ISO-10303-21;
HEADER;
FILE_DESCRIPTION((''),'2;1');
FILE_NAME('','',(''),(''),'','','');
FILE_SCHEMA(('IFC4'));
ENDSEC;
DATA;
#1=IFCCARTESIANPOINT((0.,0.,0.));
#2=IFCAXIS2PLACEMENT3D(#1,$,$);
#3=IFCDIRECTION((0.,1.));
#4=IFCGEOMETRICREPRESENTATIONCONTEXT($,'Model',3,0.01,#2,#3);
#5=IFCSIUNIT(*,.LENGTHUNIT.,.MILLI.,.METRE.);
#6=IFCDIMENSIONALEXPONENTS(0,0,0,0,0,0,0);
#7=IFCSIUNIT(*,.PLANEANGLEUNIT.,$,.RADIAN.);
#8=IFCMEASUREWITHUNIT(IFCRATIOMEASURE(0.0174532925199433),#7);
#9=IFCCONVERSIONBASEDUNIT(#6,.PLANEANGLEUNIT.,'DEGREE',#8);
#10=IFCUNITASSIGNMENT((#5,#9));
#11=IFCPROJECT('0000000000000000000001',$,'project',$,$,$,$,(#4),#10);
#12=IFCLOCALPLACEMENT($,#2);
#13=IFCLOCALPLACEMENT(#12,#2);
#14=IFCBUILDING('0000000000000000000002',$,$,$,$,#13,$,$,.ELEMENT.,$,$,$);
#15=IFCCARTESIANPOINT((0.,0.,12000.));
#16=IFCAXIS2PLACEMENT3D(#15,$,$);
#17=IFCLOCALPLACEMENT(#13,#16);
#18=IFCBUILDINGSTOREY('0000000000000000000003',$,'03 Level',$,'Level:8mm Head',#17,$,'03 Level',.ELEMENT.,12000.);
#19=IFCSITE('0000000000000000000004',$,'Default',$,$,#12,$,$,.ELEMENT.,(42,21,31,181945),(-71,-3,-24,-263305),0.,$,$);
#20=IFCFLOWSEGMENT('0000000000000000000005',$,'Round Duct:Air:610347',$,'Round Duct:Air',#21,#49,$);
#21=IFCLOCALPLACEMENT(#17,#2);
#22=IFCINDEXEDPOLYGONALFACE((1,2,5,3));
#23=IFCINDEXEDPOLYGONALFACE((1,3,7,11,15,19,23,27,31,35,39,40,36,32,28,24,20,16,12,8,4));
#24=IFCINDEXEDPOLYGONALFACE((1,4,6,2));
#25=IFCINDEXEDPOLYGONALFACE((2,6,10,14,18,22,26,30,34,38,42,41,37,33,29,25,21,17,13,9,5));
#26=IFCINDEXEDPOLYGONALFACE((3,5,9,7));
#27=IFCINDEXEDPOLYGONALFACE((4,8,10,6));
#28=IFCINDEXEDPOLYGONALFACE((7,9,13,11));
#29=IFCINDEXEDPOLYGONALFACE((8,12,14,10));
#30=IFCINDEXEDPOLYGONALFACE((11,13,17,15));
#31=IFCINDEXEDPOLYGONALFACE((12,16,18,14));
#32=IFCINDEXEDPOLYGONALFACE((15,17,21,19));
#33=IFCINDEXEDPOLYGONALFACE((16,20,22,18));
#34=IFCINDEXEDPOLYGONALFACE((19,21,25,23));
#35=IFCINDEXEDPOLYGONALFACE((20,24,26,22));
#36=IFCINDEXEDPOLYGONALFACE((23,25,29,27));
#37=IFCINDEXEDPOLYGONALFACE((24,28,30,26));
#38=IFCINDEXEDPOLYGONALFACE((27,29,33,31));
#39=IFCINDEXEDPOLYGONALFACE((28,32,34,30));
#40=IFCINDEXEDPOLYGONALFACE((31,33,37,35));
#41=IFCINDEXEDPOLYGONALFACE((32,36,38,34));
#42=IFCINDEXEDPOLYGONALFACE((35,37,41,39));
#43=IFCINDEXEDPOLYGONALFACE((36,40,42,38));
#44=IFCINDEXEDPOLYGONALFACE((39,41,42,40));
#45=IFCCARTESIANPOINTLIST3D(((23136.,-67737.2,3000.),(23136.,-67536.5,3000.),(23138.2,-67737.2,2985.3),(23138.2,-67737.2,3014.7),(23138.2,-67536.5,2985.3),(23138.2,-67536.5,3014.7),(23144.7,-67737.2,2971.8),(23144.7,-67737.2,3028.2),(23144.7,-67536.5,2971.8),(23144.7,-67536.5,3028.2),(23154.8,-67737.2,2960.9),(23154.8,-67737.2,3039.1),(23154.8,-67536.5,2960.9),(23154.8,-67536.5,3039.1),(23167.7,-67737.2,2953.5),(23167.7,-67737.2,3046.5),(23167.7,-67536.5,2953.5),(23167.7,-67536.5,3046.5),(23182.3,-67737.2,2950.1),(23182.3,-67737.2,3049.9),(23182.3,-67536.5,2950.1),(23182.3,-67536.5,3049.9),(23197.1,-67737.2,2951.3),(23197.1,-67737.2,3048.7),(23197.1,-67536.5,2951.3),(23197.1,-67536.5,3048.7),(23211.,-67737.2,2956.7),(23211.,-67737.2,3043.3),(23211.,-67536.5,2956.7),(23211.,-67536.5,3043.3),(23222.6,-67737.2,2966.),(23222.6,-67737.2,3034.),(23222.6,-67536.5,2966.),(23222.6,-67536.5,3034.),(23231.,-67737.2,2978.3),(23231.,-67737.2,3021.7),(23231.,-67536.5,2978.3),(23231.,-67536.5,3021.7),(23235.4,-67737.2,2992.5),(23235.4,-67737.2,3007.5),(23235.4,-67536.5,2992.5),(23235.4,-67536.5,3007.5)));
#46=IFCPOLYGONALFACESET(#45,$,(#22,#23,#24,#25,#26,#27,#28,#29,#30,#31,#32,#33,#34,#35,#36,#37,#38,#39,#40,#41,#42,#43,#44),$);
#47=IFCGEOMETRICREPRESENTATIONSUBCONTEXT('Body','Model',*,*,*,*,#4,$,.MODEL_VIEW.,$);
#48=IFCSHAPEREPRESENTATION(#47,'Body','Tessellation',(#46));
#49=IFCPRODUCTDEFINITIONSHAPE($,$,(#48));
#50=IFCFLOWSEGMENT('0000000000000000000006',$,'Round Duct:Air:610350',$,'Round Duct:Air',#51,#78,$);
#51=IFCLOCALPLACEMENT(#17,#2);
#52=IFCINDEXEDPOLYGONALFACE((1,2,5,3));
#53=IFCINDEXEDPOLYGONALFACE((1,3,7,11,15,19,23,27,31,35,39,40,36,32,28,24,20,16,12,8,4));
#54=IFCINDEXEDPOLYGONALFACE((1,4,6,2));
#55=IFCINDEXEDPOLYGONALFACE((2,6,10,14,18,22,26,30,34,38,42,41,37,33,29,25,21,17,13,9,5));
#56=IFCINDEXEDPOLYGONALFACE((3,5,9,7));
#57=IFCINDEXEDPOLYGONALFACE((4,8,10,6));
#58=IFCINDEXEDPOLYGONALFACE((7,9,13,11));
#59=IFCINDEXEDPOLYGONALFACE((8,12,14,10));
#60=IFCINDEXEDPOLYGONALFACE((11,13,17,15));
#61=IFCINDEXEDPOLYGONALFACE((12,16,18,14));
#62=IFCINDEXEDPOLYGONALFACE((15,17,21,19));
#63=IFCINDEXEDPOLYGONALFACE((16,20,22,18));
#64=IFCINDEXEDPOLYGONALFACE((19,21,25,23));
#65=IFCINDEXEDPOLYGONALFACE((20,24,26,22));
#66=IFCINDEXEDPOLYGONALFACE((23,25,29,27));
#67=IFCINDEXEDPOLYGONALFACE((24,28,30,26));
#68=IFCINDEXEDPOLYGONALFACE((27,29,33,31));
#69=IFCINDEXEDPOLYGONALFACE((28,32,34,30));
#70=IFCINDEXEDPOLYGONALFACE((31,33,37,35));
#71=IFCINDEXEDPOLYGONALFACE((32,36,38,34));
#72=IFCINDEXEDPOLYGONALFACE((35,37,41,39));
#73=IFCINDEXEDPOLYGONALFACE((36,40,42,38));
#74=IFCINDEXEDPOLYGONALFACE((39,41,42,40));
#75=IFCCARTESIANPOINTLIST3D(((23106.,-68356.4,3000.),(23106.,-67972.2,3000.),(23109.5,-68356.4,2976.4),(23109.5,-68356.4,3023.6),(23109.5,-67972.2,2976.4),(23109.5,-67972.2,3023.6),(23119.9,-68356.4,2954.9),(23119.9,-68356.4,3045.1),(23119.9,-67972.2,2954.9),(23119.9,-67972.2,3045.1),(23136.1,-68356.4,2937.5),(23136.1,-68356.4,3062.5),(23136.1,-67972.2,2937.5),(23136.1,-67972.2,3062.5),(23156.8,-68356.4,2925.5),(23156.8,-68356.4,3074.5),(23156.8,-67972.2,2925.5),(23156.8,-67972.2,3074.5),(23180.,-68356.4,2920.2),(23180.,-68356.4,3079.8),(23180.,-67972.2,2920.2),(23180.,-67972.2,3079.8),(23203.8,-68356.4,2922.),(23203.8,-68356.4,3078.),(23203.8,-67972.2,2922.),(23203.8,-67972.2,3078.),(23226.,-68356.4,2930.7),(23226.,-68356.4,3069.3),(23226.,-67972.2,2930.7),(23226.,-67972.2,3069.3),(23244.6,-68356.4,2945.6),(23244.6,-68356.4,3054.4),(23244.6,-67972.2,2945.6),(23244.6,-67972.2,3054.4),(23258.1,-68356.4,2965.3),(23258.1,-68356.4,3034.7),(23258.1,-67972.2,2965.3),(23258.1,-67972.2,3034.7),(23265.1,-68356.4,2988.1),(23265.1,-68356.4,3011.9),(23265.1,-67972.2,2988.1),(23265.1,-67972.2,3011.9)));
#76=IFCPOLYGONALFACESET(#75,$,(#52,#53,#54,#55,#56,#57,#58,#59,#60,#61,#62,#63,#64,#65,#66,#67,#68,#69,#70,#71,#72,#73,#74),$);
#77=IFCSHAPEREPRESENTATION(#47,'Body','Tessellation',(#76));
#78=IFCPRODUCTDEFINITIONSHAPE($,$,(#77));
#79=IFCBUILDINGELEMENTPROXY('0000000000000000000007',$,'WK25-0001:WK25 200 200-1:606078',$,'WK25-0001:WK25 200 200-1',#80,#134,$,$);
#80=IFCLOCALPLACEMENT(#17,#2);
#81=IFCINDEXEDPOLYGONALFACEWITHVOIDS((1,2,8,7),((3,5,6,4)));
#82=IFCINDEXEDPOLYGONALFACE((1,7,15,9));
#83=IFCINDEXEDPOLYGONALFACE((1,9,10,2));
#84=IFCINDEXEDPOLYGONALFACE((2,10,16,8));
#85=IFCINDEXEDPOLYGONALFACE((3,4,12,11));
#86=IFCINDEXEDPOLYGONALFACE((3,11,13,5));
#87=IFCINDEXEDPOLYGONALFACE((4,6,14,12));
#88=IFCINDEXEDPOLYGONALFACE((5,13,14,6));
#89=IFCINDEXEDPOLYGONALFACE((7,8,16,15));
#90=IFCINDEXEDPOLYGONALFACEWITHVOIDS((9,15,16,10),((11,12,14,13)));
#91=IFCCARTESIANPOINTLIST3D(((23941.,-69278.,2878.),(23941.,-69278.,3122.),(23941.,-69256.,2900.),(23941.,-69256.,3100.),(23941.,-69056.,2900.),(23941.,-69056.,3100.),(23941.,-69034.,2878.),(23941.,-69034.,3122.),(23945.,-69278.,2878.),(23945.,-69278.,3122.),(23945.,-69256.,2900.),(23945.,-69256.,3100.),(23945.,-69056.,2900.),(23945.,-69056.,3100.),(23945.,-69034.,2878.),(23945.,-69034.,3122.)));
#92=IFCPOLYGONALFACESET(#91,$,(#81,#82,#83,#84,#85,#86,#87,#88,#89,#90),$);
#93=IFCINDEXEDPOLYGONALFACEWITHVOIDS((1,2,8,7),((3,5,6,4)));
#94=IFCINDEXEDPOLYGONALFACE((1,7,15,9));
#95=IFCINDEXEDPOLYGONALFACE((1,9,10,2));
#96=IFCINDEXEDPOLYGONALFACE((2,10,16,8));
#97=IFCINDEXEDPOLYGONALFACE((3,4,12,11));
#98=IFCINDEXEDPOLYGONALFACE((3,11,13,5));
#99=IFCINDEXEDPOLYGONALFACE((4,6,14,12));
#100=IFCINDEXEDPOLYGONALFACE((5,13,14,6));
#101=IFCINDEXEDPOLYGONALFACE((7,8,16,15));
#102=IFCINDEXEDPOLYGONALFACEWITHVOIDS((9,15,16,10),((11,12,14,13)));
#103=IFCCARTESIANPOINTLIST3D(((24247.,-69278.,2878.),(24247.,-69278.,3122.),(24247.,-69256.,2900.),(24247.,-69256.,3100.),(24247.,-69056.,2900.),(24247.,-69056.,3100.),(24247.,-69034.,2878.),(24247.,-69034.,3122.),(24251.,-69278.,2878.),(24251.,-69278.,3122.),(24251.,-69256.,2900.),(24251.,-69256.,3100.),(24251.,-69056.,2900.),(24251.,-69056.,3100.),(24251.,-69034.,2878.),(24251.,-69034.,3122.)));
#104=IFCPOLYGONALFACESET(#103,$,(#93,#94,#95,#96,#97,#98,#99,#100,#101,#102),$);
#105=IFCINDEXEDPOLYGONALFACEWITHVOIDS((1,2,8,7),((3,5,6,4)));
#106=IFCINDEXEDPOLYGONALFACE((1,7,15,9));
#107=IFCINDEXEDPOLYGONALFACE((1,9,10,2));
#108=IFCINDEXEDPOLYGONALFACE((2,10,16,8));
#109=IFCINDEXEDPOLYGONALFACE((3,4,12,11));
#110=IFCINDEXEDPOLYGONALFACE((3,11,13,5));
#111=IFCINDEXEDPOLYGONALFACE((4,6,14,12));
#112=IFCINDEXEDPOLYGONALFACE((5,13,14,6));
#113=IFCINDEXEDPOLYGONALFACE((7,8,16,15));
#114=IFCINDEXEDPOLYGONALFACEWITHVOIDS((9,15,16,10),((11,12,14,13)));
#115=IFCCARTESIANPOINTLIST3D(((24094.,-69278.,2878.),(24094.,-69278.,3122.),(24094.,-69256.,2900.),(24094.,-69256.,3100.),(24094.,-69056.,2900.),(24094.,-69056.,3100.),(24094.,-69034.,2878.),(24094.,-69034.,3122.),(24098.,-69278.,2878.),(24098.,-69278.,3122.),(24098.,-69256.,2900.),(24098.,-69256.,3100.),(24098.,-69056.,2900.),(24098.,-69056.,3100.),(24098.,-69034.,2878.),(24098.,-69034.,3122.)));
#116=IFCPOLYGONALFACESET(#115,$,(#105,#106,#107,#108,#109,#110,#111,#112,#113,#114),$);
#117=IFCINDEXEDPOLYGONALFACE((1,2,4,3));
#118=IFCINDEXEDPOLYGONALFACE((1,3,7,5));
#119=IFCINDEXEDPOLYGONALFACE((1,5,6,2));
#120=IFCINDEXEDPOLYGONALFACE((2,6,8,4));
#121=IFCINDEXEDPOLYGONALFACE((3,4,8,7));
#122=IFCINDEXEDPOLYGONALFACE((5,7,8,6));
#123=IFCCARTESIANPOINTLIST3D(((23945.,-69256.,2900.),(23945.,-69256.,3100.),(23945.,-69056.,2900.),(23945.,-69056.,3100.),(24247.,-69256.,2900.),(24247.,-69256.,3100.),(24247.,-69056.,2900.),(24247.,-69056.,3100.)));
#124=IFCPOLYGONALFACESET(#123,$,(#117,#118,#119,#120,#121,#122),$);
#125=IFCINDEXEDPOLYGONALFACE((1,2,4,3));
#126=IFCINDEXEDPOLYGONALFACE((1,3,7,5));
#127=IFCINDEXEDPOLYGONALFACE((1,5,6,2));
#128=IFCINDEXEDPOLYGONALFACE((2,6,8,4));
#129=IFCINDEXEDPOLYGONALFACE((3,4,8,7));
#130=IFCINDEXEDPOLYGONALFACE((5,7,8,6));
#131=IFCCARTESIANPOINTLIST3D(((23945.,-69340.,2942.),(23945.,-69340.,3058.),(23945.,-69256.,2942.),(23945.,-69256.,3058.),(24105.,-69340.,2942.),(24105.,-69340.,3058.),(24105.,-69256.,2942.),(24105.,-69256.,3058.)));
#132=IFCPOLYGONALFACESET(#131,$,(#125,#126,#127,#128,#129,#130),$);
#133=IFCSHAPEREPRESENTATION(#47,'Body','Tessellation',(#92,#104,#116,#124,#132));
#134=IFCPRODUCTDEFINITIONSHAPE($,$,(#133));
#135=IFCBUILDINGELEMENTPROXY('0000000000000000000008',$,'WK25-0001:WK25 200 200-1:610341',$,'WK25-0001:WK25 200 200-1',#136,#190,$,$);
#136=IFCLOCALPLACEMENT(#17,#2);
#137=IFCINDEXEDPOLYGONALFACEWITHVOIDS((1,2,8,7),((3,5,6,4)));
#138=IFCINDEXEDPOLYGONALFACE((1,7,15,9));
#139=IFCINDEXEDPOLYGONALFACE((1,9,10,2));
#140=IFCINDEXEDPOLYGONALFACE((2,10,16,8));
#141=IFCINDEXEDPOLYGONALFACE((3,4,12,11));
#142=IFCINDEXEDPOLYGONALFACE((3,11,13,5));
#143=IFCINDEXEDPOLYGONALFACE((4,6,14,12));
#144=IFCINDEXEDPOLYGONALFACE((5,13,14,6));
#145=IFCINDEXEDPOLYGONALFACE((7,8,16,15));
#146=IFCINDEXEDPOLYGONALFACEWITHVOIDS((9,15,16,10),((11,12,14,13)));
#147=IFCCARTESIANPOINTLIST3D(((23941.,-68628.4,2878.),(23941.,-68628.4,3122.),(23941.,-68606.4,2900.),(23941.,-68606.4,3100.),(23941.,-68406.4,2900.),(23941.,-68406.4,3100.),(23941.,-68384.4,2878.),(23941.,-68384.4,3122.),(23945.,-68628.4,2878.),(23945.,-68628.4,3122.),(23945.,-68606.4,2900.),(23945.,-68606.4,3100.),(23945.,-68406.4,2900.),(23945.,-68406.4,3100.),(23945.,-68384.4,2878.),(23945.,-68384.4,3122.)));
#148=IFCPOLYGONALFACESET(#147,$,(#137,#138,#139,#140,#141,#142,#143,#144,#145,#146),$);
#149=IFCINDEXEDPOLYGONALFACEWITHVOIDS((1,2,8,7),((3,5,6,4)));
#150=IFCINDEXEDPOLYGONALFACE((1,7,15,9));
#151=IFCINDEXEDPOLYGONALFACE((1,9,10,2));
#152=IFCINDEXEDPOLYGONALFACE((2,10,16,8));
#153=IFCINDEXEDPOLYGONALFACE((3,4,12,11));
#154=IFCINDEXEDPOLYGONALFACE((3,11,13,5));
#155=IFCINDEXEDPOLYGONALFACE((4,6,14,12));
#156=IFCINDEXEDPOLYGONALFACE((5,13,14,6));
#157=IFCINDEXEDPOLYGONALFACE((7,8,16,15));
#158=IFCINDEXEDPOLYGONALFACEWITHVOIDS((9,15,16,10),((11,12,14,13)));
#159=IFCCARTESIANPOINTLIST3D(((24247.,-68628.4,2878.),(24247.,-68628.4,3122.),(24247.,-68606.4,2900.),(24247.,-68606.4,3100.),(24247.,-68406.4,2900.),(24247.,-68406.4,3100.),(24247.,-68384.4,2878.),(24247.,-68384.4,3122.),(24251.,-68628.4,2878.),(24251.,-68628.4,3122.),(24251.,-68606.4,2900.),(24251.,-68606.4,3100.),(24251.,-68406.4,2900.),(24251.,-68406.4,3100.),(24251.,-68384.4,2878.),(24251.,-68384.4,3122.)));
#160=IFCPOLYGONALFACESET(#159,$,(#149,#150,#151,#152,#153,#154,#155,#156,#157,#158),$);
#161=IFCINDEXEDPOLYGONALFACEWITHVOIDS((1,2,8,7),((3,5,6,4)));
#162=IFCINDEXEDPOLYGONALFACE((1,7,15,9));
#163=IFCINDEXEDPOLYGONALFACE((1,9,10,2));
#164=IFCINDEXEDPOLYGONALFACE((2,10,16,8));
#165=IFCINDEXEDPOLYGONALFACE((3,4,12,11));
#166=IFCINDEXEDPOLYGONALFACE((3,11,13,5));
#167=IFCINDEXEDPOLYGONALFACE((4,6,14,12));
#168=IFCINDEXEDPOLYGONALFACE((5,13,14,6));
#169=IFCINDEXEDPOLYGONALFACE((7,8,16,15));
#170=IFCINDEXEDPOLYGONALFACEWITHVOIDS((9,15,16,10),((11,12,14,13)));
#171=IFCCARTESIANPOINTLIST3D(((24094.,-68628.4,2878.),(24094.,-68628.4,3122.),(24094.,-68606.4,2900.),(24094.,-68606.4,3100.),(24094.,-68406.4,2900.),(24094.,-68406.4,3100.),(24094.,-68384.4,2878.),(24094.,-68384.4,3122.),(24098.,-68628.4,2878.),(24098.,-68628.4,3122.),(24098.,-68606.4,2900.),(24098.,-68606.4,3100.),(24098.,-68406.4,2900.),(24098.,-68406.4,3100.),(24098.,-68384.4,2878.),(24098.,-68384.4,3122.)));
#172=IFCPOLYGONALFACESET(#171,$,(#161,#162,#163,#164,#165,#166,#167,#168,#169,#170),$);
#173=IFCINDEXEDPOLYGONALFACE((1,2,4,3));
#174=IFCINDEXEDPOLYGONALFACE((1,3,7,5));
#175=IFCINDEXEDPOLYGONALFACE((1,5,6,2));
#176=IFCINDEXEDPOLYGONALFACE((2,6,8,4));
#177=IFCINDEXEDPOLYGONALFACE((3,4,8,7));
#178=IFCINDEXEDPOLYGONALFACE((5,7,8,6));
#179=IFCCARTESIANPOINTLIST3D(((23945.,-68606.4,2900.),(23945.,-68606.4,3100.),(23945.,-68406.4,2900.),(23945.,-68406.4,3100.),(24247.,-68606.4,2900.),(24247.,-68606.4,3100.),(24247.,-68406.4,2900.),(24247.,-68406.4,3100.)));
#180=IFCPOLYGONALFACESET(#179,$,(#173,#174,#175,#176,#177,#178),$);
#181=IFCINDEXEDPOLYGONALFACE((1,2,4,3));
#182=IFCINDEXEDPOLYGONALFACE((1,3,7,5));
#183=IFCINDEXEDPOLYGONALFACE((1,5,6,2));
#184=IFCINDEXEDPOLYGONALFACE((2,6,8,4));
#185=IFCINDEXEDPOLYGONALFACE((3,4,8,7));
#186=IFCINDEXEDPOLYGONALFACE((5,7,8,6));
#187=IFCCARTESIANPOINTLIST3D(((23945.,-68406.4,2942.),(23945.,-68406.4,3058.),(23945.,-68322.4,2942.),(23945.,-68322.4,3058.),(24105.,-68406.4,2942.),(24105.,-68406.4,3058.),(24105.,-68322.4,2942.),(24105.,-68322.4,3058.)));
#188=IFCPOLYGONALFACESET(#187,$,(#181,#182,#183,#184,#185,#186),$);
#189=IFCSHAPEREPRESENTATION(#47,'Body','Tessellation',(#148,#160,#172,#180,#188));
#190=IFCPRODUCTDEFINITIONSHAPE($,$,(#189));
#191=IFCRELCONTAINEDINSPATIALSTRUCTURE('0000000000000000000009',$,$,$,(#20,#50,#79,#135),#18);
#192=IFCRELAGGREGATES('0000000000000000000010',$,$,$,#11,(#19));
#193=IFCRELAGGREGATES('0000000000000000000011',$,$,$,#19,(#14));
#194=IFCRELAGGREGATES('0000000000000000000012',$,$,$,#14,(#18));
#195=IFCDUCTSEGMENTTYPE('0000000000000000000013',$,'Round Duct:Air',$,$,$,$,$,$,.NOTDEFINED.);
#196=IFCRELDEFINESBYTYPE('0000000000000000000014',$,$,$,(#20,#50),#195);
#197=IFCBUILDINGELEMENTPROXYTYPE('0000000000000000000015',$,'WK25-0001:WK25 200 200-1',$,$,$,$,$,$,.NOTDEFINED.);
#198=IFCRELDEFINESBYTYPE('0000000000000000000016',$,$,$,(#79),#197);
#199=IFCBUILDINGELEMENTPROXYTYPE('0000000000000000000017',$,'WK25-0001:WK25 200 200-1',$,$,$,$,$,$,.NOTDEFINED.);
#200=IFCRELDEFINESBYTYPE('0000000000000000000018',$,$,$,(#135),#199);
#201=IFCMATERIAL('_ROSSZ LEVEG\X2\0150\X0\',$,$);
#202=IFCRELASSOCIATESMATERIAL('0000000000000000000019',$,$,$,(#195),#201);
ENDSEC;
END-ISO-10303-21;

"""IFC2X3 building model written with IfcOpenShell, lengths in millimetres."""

from ifc_helpers import new_model, entity, si_unit, converted_unit, direction, frame, frame_2d, origin, origin_2d_with_axis, place, context, subcontext, project, spatial, polyline, rectangle, circle, outline, extrude, source, transform, mapped, material, type_object, type_shapes, element, save


model = new_model("IFC2X3")

# Units and contexts
model_context = context("Model", 3, precision=0.01, world=origin(), true_north=direction((0.0, 1.0)))
body_context = subcontext(model_context, "Body", "Model", "MODEL_VIEW")
ifc_project = project(units=[si_unit("LENGTHUNIT", "METRE", prefix="MILLI"), converted_unit("PLANEANGLEUNIT", "DEGREE", entity("IfcRatioMeasure", 0.0174532925199433), si_unit("PLANEANGLEUNIT", "RADIAN"), dimensions=[0, 0, 0, 0, 0, 0, 0])], contexts=[model_context])

# Site, building, storey
site_placement = place(None, origin())
site = spatial("IfcSite", under=ifc_project, at=site_placement, Name="Default", CompositionType="ELEMENT", RefLatitude=(42, 21, 31, 181945), RefLongitude=(-71, -3, -24, -263305), RefElevation=0.0)
building_placement = place(site_placement, origin())
building = spatial("IfcBuilding", under=site, at=building_placement, CompositionType="ELEMENT")
storey_placement = place(building_placement, frame((0.0, 0.0, 12000.0)))
storey = spatial("IfcBuildingStorey", under=building, at=storey_placement, Name="03 Level", ObjectType="Level:8mm Head", LongName="03 Level", CompositionType="ELEMENT", Elevation=12000.0)

# Flow segments
ifc_material = material(Name="_ROSSZ LEVEGŐ")
duct_segment_type_1 = type_object("IfcDuctSegmentType", Name="Round Duct:Air", PredefinedType="NOTDEFINED", material=ifc_material)
flow_segment_1_placement = place(storey_placement, origin())
element("IfcFlowSegment", 1, at=flow_segment_1_placement, inside=storey, type_object=duct_segment_type_1, Name="Round Duct:Air:610347", ObjectType="Round Duct:Air", context=body_context, shape_type="SweptSolid", body=[
    extrude(circle(Radius=50.0, at=frame_2d((0.0, 0.0), x_axis=(1.0, 0.0))), frame((23186.0, -67737.2, 3000.0), z_axis=(0.0, 1.0, 0.0), x_axis=(-1.0, 0.0, 0.0)), (0.0, 0.0, 1.0), 200.7),
])
flow_segment_2_placement = place(storey_placement, origin())
element("IfcFlowSegment", 2, at=flow_segment_2_placement, inside=storey, type_object=duct_segment_type_1, Name="Round Duct:Air:610350", ObjectType="Round Duct:Air", context=body_context, shape_type="SweptSolid", body=[
    extrude(circle(Radius=80.0, at=frame_2d((0.0, 0.0), x_axis=(1.0, 0.0))), frame((23186.0, -68356.4, 3000.0), z_axis=(0.0, 1.0, 0.0), x_axis=(-1.0, 0.0, 0.0)), (0.0, 0.0, 1.0), 384.2),
])

# Building element proxies
building_element_proxy_type_1 = type_object("IfcBuildingElementProxyType", Name="WK25-0001:WK25 200 200-1", PredefinedType="NOTDEFINED")
shared_shape_1 = source(origin(), body_context, "Body", "SweptSolid", [
    extrude(outline(polyline([(-122.0, -122.0), (122.0, -122.0), (122.0, 122.0), (-122.0, 122.0), (-122.0, -122.0)]), holes=[polyline([(-100.0, -100.0), (-100.0, 100.0), (100.0, 100.0), (100.0, -100.0), (-100.0, -100.0)])]), frame((151.0, 0.0, 0.0), z_axis=(1.0, 0.0, 0.0), x_axis=(0.0, 0.0, -1.0)), (0.0, 0.0, 1.0), 4.0),
    extrude(outline(polyline([(-122.0, -122.0), (122.0, -122.0), (122.0, 122.0), (-122.0, 122.0), (-122.0, -122.0)]), holes=[polyline([(-100.0, -100.0), (-100.0, 100.0), (100.0, 100.0), (100.0, -100.0), (-100.0, -100.0)])]), frame((-155.0, 0.0, 0.0), z_axis=(1.0, 0.0, 0.0), x_axis=(0.0, -1.0, 0.0)), (0.0, 0.0, 1.0), 4.0),
    extrude(outline(polyline([(-122.0, -122.0), (122.0, -122.0), (122.0, 122.0), (-122.0, 122.0), (-122.0, -122.0)]), holes=[polyline([(-100.0, -100.0), (-100.0, 100.0), (100.0, 100.0), (100.0, -100.0), (-100.0, -100.0)])]), frame((-2.0, 0.0, 0.0), z_axis=(1.0, 0.0, 0.0), x_axis=(0.0, -1.0, 0.0)), (0.0, 0.0, 1.0), 4.0),
    extrude(rectangle(XDim=302.0, YDim=200.0, at=origin_2d_with_axis()), frame((0.0, 0.0, -100.0), z_axis=(0.0, 0.0, 1.0), x_axis=(-1.0, 0.0, 0.0)), (0.0, 0.0, 1.0), 200.0),
    extrude(rectangle(XDim=84.0, YDim=160.0, at=frame_2d((0.0, 0.0), x_axis=(1.0, 0.0))), frame((71.0, -142.0, -58.0), z_axis=(0.0, 0.0, 1.0), x_axis=(0.0, -1.0, 0.0)), (0.0, 0.0, 1.0), 116.0),
])
type_shapes(building_element_proxy_type_1, [shared_shape_1])
proxy_1_placement = place(storey_placement, frame((24096.0, -69156.0, 3000.0), z_axis=(0.0, 0.0, -1.0), x_axis=(-1.0, 0.0, 0.0)))
element("IfcBuildingElementProxy", 3, at=proxy_1_placement, inside=storey, type_object=building_element_proxy_type_1, Name="WK25-0001:WK25 200 200-1:606078", ObjectType="WK25-0001:WK25 200 200-1", context=body_context, shape_type="MappedRepresentation", body=[
    mapped(shared_shape_1, transform((0.0, 0.0, 0.0), scale=1.0)),
])
building_element_proxy_type_2 = type_object("IfcBuildingElementProxyType", Name="WK25-0001:WK25 200 200-1", PredefinedType="NOTDEFINED")
shared_shape_2 = source(origin(), body_context, "Body", "SweptSolid", [
    extrude(outline(polyline([(-122.0, -122.0), (122.0, -122.0), (122.0, 122.0), (-122.0, 122.0), (-122.0, -122.0)]), holes=[polyline([(-100.0, -100.0), (-100.0, 100.0), (100.0, 100.0), (100.0, -100.0), (-100.0, -100.0)])]), frame((151.0, 0.0, 0.0), z_axis=(1.0, 0.0, 0.0), x_axis=(0.0, -1.0, 0.0)), (0.0, 0.0, 1.0), 4.0),
    extrude(outline(polyline([(-122.0, -122.0), (122.0, -122.0), (122.0, 122.0), (-122.0, 122.0), (-122.0, -122.0)]), holes=[polyline([(-100.0, -100.0), (-100.0, 100.0), (100.0, 100.0), (100.0, -100.0), (-100.0, -100.0)])]), frame((-155.0, 0.0, 0.0), z_axis=(1.0, 0.0, 0.0), x_axis=(0.0, 0.0, -1.0)), (0.0, 0.0, 1.0), 4.0),
    extrude(outline(polyline([(-122.0, -122.0), (122.0, -122.0), (122.0, 122.0), (-122.0, 122.0), (-122.0, -122.0)]), holes=[polyline([(-100.0, -100.0), (-100.0, 100.0), (100.0, 100.0), (100.0, -100.0), (-100.0, -100.0)])]), frame((-2.0, 0.0, 0.0), z_axis=(1.0, 0.0, 0.0), x_axis=(0.0, 0.0, -1.0)), (0.0, 0.0, 1.0), 4.0),
    extrude(rectangle(XDim=200.0, YDim=302.0, at=origin_2d_with_axis()), frame((0.0, 0.0, -100.0), z_axis=(0.0, 0.0, 1.0), x_axis=(0.0, 1.0, 0.0)), (0.0, 0.0, 1.0), 200.0),
    extrude(rectangle(XDim=160.0, YDim=84.0, at=frame_2d((0.0, 0.0), x_axis=(1.0, 0.0))), frame((71.0, 142.0, -58.0)), (0.0, 0.0, 1.0), 116.0),
])
type_shapes(building_element_proxy_type_2, [shared_shape_2])
proxy_2_placement = place(storey_placement, frame((24096.0, -68506.4, 3000.0), z_axis=(0.0, 0.0, -1.0), x_axis=(-1.0, 0.0, 0.0)))
element("IfcBuildingElementProxy", 4, at=proxy_2_placement, inside=storey, type_object=building_element_proxy_type_2, Name="WK25-0001:WK25 200 200-1:610341", ObjectType="WK25-0001:WK25 200 200-1", context=body_context, shape_type="MappedRepresentation", body=[
    mapped(shared_shape_2, transform((0.0, 0.0, 0.0), scale=1.0)),
])

save(model, "model.ifc")
